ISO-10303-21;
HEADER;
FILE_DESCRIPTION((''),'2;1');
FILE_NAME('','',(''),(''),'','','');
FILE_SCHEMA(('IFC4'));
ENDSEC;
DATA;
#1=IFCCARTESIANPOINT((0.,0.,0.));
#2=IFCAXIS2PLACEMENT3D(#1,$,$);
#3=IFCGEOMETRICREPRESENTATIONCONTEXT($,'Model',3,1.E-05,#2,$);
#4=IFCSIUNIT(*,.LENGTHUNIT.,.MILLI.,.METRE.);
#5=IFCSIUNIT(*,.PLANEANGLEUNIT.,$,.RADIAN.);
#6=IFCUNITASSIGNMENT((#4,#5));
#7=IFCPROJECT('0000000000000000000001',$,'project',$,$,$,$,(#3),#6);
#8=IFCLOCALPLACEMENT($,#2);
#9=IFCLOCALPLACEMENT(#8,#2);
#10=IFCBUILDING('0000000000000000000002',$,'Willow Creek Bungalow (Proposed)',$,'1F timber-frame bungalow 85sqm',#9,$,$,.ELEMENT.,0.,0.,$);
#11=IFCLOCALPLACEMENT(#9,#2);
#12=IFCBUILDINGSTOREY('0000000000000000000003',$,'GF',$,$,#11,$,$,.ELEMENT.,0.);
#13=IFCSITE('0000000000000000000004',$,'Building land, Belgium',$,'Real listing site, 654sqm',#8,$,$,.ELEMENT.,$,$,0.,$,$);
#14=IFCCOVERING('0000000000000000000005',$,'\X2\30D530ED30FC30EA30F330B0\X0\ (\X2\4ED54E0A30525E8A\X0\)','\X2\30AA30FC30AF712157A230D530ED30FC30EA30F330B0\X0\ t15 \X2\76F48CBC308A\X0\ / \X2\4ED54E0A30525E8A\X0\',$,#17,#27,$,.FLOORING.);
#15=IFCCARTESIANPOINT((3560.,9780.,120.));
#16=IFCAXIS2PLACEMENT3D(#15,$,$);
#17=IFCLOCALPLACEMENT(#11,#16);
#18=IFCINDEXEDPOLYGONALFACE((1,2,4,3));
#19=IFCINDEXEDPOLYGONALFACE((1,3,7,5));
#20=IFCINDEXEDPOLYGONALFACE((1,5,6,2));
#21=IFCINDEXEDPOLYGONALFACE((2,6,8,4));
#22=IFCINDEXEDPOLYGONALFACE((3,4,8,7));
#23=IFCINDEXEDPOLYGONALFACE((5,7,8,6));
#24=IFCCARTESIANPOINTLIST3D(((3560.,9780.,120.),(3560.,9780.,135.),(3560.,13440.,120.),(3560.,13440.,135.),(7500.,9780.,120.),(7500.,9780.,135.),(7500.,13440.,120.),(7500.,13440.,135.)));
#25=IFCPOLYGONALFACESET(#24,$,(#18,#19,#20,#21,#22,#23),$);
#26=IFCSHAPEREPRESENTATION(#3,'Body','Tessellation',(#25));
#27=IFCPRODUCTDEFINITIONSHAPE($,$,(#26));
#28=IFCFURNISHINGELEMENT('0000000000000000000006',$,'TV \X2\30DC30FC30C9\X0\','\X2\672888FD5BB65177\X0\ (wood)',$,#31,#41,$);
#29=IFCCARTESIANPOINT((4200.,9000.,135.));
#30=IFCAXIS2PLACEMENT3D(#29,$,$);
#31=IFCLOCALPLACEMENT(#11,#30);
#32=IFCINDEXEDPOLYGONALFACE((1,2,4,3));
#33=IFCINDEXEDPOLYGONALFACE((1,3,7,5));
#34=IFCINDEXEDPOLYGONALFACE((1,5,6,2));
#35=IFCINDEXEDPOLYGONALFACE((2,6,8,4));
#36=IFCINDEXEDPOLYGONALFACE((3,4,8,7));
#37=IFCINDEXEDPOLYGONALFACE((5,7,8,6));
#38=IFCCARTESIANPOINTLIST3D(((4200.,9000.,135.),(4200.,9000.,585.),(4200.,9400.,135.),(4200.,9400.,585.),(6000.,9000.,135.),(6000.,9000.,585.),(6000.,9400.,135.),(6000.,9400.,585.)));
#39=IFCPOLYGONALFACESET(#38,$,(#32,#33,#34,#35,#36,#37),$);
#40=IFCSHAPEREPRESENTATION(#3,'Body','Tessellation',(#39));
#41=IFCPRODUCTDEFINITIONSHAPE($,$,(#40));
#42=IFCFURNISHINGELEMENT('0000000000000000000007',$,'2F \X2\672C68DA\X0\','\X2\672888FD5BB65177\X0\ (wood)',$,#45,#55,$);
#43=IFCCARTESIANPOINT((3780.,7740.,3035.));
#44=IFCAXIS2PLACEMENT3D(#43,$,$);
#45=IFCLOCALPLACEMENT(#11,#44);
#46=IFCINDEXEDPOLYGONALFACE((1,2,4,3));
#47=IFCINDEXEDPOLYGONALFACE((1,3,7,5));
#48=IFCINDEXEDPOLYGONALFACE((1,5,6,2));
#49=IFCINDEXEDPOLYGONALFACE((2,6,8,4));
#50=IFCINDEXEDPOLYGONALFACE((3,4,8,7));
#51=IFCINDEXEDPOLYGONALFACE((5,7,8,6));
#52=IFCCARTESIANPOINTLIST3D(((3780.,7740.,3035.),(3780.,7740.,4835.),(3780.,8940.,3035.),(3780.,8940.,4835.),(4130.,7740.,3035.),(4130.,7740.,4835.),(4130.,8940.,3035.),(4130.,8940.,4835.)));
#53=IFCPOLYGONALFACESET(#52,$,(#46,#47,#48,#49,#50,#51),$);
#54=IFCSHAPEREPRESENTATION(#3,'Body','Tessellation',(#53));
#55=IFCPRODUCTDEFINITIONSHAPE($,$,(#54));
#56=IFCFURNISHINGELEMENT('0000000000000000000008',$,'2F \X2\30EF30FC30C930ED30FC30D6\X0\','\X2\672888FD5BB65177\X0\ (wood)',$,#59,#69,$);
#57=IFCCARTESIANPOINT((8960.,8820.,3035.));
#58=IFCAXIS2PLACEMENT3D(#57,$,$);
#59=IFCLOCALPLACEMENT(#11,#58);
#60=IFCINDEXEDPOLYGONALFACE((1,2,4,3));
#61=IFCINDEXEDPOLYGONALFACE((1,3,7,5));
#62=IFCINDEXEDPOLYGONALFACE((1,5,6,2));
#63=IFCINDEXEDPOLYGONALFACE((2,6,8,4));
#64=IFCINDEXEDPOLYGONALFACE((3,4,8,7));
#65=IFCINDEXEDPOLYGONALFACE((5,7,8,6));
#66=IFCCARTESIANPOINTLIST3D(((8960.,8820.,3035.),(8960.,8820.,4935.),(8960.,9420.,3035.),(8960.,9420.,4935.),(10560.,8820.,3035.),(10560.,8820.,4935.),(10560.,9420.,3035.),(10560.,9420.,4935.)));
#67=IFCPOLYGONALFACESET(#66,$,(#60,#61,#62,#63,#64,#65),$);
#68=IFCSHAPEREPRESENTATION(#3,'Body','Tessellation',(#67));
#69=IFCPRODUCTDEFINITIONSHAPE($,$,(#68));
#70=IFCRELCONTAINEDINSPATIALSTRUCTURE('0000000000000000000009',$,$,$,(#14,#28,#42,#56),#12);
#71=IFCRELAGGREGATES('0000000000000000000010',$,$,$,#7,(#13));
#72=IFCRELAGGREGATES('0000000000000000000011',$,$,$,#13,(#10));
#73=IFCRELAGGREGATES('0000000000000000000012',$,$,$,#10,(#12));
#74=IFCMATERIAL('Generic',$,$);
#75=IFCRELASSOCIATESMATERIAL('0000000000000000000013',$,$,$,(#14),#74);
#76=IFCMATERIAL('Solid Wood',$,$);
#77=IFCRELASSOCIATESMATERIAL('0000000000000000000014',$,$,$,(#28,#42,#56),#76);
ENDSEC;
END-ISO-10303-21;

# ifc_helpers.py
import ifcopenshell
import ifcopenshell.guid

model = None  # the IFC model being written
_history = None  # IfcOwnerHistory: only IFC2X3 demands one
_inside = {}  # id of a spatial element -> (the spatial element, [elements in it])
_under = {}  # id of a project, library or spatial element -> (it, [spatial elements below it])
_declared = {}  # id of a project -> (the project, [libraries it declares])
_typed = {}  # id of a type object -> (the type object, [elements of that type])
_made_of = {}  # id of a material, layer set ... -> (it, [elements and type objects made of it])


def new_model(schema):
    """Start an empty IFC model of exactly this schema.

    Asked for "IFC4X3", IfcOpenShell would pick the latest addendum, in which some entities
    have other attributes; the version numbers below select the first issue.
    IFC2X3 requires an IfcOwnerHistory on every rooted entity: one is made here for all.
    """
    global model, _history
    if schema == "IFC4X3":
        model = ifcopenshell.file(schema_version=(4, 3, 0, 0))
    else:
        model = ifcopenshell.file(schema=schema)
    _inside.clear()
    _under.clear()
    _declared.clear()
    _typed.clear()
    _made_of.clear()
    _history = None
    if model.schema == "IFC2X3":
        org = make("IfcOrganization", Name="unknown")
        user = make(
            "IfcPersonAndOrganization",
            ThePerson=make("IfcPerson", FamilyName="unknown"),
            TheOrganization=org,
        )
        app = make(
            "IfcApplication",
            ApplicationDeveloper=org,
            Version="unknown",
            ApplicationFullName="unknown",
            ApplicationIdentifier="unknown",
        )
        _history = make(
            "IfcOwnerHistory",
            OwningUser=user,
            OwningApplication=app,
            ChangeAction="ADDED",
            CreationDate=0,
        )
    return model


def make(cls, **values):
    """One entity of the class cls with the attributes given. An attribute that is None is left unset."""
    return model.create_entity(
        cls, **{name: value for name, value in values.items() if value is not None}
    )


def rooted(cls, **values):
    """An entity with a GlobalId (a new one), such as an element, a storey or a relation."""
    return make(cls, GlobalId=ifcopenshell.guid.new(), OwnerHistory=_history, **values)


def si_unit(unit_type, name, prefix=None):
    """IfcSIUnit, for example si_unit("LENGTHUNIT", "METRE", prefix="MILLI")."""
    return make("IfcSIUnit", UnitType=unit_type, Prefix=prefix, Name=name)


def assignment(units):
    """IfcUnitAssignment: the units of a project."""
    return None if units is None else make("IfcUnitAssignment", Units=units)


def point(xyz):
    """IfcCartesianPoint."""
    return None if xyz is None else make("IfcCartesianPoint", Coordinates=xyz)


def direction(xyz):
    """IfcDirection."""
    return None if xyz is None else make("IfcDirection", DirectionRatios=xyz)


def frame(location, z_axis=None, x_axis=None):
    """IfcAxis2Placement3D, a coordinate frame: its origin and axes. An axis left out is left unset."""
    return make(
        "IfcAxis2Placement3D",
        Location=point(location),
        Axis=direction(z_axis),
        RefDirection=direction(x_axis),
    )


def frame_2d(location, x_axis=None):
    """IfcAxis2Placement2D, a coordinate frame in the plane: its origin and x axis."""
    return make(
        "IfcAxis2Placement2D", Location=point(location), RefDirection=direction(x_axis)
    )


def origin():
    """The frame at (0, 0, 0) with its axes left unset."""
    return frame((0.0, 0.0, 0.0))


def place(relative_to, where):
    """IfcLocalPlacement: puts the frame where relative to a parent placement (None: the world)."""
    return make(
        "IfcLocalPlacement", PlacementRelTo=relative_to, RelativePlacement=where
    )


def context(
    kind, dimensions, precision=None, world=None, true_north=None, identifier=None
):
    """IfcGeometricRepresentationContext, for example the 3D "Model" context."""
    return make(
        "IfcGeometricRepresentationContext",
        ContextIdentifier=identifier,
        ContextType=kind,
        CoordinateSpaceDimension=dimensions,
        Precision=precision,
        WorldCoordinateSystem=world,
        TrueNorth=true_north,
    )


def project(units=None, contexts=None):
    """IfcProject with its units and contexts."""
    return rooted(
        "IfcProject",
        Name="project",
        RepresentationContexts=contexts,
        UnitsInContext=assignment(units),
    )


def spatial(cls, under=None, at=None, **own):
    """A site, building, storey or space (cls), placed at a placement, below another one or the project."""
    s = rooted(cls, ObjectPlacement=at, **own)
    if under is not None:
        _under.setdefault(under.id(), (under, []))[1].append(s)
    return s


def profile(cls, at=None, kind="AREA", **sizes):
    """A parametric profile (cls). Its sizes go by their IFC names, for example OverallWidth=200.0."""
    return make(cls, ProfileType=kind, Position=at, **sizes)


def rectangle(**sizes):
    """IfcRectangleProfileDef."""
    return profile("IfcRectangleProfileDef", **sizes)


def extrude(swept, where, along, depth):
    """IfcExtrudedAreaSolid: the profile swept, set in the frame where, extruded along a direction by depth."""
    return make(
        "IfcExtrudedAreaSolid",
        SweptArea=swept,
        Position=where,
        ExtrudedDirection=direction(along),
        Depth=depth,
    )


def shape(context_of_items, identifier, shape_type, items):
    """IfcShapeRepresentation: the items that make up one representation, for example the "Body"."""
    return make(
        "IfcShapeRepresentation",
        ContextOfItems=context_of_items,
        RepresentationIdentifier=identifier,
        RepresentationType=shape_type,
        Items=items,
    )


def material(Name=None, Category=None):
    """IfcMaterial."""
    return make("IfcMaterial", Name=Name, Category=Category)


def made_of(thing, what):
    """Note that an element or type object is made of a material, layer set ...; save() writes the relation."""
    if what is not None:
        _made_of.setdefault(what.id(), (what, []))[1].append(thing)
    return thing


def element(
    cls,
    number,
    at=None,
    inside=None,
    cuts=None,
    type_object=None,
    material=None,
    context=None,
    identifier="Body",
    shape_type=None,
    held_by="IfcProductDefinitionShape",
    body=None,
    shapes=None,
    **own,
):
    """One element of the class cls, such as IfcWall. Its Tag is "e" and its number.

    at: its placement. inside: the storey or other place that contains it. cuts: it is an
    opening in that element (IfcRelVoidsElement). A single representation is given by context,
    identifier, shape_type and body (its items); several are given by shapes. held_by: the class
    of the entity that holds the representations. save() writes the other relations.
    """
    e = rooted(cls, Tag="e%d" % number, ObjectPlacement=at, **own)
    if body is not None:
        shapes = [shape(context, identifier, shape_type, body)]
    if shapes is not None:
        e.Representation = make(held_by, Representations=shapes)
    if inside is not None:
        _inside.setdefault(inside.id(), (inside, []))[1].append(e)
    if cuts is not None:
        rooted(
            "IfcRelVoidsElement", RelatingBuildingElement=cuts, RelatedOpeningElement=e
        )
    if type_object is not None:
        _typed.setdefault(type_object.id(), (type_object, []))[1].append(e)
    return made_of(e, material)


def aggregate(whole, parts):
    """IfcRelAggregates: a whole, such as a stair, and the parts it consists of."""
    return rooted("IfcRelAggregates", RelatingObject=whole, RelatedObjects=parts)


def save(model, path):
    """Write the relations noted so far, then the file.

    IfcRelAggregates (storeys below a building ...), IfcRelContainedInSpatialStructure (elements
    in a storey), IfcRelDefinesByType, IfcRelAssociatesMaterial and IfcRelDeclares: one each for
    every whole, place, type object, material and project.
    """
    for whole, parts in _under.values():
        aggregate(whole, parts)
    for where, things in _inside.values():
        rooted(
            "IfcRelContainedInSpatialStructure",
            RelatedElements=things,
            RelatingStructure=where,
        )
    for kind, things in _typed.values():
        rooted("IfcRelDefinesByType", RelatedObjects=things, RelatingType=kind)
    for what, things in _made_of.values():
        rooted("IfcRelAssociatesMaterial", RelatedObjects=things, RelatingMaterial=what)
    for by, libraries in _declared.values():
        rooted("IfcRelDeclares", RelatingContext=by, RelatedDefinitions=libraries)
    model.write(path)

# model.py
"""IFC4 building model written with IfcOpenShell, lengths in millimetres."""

from ifc_helpers import new_model, si_unit, frame, frame_2d, origin, place, context, project, spatial, rectangle, extrude, material, element, save


model = new_model("IFC4")

# Units and contexts
model_context = context("Model", 3, precision=1e-05, world=origin())
ifc_project = project(units=[si_unit("LENGTHUNIT", "METRE", prefix="MILLI"), si_unit("PLANEANGLEUNIT", "RADIAN")], contexts=[model_context])

# Site, building, storey
site_placement = place(None, origin())
site = spatial("IfcSite", under=ifc_project, at=site_placement, Name="Building land, Belgium", ObjectType="Real listing site, 654sqm", CompositionType="ELEMENT", RefElevation=0.0)
building_placement = place(site_placement, origin())
building = spatial("IfcBuilding", under=site, at=building_placement, Name="Willow Creek Bungalow (Proposed)", ObjectType="1F timber-frame bungalow 85sqm", CompositionType="ELEMENT", ElevationOfRefHeight=0.0, ElevationOfTerrain=0.0)
storey_placement = place(building_placement, origin())
storey = spatial("IfcBuildingStorey", under=building, at=storey_placement, Name="GF", CompositionType="ELEMENT", Elevation=0.0)

# Shared definitions
ifc_material_1 = material(Name="Solid Wood")

# Shared definitions
ifc_material_2 = material(Name="Generic")

# Covering
covering_placement = place(storey_placement, frame((3560.0, 9780.0, 120.0)))
element("IfcCovering", 1, at=covering_placement, inside=storey, material=ifc_material_2, Name="フローリング (仕上げ床)", Description="オーク無垢フローリング t15 直貼り / 仕上げ床", PredefinedType="FLOORING", context=model_context, shape_type="SweptSolid", body=[
    extrude(rectangle(XDim=3940.0, YDim=3660.0, at=frame_2d((1970.0, 1830.0))), frame((3560.0, 9780.0, 120.0)), (0.0, 0.0, 1.0), 15.0),
])

# Furnishing elements
furnishing_1_placement = place(storey_placement, frame((4200.0, 9000.0, 135.0)))
element("IfcFurnishingElement", 2, at=furnishing_1_placement, inside=storey, material=ifc_material_1, Name="TV ボード", Description="木製家具 (wood)", context=model_context, shape_type="SweptSolid", body=[
    extrude(rectangle(XDim=1800.0, YDim=400.0, at=frame_2d((900.0, 200.0))), frame((4200.0, 9000.0, 135.0)), (0.0, 0.0, 1.0), 450.0),
])
furnishing_2_placement = place(storey_placement, frame((3780.0, 7740.0, 3035.0)))
element("IfcFurnishingElement", 3, at=furnishing_2_placement, inside=storey, material=ifc_material_1, Name="2F 本棚", Description="木製家具 (wood)", context=model_context, shape_type="SweptSolid", body=[
    extrude(rectangle(XDim=350.0, YDim=1200.0, at=frame_2d((175.0, 600.0))), frame((3780.0, 7740.0, 3035.0)), (0.0, 0.0, 1.0), 1800.0),
])
furnishing_3_placement = place(storey_placement, frame((8960.0, 8820.0, 3035.0)))
element("IfcFurnishingElement", 4, at=furnishing_3_placement, inside=storey, material=ifc_material_1, Name="2F ワードローブ", Description="木製家具 (wood)", context=model_context, shape_type="SweptSolid", body=[
    extrude(rectangle(XDim=1600.0, YDim=600.0, at=frame_2d((800.0, 300.0))), frame((8960.0, 8820.0, 3035.0)), (0.0, 0.0, 1.0), 1900.0),
])

save(model, "model.ifc")
